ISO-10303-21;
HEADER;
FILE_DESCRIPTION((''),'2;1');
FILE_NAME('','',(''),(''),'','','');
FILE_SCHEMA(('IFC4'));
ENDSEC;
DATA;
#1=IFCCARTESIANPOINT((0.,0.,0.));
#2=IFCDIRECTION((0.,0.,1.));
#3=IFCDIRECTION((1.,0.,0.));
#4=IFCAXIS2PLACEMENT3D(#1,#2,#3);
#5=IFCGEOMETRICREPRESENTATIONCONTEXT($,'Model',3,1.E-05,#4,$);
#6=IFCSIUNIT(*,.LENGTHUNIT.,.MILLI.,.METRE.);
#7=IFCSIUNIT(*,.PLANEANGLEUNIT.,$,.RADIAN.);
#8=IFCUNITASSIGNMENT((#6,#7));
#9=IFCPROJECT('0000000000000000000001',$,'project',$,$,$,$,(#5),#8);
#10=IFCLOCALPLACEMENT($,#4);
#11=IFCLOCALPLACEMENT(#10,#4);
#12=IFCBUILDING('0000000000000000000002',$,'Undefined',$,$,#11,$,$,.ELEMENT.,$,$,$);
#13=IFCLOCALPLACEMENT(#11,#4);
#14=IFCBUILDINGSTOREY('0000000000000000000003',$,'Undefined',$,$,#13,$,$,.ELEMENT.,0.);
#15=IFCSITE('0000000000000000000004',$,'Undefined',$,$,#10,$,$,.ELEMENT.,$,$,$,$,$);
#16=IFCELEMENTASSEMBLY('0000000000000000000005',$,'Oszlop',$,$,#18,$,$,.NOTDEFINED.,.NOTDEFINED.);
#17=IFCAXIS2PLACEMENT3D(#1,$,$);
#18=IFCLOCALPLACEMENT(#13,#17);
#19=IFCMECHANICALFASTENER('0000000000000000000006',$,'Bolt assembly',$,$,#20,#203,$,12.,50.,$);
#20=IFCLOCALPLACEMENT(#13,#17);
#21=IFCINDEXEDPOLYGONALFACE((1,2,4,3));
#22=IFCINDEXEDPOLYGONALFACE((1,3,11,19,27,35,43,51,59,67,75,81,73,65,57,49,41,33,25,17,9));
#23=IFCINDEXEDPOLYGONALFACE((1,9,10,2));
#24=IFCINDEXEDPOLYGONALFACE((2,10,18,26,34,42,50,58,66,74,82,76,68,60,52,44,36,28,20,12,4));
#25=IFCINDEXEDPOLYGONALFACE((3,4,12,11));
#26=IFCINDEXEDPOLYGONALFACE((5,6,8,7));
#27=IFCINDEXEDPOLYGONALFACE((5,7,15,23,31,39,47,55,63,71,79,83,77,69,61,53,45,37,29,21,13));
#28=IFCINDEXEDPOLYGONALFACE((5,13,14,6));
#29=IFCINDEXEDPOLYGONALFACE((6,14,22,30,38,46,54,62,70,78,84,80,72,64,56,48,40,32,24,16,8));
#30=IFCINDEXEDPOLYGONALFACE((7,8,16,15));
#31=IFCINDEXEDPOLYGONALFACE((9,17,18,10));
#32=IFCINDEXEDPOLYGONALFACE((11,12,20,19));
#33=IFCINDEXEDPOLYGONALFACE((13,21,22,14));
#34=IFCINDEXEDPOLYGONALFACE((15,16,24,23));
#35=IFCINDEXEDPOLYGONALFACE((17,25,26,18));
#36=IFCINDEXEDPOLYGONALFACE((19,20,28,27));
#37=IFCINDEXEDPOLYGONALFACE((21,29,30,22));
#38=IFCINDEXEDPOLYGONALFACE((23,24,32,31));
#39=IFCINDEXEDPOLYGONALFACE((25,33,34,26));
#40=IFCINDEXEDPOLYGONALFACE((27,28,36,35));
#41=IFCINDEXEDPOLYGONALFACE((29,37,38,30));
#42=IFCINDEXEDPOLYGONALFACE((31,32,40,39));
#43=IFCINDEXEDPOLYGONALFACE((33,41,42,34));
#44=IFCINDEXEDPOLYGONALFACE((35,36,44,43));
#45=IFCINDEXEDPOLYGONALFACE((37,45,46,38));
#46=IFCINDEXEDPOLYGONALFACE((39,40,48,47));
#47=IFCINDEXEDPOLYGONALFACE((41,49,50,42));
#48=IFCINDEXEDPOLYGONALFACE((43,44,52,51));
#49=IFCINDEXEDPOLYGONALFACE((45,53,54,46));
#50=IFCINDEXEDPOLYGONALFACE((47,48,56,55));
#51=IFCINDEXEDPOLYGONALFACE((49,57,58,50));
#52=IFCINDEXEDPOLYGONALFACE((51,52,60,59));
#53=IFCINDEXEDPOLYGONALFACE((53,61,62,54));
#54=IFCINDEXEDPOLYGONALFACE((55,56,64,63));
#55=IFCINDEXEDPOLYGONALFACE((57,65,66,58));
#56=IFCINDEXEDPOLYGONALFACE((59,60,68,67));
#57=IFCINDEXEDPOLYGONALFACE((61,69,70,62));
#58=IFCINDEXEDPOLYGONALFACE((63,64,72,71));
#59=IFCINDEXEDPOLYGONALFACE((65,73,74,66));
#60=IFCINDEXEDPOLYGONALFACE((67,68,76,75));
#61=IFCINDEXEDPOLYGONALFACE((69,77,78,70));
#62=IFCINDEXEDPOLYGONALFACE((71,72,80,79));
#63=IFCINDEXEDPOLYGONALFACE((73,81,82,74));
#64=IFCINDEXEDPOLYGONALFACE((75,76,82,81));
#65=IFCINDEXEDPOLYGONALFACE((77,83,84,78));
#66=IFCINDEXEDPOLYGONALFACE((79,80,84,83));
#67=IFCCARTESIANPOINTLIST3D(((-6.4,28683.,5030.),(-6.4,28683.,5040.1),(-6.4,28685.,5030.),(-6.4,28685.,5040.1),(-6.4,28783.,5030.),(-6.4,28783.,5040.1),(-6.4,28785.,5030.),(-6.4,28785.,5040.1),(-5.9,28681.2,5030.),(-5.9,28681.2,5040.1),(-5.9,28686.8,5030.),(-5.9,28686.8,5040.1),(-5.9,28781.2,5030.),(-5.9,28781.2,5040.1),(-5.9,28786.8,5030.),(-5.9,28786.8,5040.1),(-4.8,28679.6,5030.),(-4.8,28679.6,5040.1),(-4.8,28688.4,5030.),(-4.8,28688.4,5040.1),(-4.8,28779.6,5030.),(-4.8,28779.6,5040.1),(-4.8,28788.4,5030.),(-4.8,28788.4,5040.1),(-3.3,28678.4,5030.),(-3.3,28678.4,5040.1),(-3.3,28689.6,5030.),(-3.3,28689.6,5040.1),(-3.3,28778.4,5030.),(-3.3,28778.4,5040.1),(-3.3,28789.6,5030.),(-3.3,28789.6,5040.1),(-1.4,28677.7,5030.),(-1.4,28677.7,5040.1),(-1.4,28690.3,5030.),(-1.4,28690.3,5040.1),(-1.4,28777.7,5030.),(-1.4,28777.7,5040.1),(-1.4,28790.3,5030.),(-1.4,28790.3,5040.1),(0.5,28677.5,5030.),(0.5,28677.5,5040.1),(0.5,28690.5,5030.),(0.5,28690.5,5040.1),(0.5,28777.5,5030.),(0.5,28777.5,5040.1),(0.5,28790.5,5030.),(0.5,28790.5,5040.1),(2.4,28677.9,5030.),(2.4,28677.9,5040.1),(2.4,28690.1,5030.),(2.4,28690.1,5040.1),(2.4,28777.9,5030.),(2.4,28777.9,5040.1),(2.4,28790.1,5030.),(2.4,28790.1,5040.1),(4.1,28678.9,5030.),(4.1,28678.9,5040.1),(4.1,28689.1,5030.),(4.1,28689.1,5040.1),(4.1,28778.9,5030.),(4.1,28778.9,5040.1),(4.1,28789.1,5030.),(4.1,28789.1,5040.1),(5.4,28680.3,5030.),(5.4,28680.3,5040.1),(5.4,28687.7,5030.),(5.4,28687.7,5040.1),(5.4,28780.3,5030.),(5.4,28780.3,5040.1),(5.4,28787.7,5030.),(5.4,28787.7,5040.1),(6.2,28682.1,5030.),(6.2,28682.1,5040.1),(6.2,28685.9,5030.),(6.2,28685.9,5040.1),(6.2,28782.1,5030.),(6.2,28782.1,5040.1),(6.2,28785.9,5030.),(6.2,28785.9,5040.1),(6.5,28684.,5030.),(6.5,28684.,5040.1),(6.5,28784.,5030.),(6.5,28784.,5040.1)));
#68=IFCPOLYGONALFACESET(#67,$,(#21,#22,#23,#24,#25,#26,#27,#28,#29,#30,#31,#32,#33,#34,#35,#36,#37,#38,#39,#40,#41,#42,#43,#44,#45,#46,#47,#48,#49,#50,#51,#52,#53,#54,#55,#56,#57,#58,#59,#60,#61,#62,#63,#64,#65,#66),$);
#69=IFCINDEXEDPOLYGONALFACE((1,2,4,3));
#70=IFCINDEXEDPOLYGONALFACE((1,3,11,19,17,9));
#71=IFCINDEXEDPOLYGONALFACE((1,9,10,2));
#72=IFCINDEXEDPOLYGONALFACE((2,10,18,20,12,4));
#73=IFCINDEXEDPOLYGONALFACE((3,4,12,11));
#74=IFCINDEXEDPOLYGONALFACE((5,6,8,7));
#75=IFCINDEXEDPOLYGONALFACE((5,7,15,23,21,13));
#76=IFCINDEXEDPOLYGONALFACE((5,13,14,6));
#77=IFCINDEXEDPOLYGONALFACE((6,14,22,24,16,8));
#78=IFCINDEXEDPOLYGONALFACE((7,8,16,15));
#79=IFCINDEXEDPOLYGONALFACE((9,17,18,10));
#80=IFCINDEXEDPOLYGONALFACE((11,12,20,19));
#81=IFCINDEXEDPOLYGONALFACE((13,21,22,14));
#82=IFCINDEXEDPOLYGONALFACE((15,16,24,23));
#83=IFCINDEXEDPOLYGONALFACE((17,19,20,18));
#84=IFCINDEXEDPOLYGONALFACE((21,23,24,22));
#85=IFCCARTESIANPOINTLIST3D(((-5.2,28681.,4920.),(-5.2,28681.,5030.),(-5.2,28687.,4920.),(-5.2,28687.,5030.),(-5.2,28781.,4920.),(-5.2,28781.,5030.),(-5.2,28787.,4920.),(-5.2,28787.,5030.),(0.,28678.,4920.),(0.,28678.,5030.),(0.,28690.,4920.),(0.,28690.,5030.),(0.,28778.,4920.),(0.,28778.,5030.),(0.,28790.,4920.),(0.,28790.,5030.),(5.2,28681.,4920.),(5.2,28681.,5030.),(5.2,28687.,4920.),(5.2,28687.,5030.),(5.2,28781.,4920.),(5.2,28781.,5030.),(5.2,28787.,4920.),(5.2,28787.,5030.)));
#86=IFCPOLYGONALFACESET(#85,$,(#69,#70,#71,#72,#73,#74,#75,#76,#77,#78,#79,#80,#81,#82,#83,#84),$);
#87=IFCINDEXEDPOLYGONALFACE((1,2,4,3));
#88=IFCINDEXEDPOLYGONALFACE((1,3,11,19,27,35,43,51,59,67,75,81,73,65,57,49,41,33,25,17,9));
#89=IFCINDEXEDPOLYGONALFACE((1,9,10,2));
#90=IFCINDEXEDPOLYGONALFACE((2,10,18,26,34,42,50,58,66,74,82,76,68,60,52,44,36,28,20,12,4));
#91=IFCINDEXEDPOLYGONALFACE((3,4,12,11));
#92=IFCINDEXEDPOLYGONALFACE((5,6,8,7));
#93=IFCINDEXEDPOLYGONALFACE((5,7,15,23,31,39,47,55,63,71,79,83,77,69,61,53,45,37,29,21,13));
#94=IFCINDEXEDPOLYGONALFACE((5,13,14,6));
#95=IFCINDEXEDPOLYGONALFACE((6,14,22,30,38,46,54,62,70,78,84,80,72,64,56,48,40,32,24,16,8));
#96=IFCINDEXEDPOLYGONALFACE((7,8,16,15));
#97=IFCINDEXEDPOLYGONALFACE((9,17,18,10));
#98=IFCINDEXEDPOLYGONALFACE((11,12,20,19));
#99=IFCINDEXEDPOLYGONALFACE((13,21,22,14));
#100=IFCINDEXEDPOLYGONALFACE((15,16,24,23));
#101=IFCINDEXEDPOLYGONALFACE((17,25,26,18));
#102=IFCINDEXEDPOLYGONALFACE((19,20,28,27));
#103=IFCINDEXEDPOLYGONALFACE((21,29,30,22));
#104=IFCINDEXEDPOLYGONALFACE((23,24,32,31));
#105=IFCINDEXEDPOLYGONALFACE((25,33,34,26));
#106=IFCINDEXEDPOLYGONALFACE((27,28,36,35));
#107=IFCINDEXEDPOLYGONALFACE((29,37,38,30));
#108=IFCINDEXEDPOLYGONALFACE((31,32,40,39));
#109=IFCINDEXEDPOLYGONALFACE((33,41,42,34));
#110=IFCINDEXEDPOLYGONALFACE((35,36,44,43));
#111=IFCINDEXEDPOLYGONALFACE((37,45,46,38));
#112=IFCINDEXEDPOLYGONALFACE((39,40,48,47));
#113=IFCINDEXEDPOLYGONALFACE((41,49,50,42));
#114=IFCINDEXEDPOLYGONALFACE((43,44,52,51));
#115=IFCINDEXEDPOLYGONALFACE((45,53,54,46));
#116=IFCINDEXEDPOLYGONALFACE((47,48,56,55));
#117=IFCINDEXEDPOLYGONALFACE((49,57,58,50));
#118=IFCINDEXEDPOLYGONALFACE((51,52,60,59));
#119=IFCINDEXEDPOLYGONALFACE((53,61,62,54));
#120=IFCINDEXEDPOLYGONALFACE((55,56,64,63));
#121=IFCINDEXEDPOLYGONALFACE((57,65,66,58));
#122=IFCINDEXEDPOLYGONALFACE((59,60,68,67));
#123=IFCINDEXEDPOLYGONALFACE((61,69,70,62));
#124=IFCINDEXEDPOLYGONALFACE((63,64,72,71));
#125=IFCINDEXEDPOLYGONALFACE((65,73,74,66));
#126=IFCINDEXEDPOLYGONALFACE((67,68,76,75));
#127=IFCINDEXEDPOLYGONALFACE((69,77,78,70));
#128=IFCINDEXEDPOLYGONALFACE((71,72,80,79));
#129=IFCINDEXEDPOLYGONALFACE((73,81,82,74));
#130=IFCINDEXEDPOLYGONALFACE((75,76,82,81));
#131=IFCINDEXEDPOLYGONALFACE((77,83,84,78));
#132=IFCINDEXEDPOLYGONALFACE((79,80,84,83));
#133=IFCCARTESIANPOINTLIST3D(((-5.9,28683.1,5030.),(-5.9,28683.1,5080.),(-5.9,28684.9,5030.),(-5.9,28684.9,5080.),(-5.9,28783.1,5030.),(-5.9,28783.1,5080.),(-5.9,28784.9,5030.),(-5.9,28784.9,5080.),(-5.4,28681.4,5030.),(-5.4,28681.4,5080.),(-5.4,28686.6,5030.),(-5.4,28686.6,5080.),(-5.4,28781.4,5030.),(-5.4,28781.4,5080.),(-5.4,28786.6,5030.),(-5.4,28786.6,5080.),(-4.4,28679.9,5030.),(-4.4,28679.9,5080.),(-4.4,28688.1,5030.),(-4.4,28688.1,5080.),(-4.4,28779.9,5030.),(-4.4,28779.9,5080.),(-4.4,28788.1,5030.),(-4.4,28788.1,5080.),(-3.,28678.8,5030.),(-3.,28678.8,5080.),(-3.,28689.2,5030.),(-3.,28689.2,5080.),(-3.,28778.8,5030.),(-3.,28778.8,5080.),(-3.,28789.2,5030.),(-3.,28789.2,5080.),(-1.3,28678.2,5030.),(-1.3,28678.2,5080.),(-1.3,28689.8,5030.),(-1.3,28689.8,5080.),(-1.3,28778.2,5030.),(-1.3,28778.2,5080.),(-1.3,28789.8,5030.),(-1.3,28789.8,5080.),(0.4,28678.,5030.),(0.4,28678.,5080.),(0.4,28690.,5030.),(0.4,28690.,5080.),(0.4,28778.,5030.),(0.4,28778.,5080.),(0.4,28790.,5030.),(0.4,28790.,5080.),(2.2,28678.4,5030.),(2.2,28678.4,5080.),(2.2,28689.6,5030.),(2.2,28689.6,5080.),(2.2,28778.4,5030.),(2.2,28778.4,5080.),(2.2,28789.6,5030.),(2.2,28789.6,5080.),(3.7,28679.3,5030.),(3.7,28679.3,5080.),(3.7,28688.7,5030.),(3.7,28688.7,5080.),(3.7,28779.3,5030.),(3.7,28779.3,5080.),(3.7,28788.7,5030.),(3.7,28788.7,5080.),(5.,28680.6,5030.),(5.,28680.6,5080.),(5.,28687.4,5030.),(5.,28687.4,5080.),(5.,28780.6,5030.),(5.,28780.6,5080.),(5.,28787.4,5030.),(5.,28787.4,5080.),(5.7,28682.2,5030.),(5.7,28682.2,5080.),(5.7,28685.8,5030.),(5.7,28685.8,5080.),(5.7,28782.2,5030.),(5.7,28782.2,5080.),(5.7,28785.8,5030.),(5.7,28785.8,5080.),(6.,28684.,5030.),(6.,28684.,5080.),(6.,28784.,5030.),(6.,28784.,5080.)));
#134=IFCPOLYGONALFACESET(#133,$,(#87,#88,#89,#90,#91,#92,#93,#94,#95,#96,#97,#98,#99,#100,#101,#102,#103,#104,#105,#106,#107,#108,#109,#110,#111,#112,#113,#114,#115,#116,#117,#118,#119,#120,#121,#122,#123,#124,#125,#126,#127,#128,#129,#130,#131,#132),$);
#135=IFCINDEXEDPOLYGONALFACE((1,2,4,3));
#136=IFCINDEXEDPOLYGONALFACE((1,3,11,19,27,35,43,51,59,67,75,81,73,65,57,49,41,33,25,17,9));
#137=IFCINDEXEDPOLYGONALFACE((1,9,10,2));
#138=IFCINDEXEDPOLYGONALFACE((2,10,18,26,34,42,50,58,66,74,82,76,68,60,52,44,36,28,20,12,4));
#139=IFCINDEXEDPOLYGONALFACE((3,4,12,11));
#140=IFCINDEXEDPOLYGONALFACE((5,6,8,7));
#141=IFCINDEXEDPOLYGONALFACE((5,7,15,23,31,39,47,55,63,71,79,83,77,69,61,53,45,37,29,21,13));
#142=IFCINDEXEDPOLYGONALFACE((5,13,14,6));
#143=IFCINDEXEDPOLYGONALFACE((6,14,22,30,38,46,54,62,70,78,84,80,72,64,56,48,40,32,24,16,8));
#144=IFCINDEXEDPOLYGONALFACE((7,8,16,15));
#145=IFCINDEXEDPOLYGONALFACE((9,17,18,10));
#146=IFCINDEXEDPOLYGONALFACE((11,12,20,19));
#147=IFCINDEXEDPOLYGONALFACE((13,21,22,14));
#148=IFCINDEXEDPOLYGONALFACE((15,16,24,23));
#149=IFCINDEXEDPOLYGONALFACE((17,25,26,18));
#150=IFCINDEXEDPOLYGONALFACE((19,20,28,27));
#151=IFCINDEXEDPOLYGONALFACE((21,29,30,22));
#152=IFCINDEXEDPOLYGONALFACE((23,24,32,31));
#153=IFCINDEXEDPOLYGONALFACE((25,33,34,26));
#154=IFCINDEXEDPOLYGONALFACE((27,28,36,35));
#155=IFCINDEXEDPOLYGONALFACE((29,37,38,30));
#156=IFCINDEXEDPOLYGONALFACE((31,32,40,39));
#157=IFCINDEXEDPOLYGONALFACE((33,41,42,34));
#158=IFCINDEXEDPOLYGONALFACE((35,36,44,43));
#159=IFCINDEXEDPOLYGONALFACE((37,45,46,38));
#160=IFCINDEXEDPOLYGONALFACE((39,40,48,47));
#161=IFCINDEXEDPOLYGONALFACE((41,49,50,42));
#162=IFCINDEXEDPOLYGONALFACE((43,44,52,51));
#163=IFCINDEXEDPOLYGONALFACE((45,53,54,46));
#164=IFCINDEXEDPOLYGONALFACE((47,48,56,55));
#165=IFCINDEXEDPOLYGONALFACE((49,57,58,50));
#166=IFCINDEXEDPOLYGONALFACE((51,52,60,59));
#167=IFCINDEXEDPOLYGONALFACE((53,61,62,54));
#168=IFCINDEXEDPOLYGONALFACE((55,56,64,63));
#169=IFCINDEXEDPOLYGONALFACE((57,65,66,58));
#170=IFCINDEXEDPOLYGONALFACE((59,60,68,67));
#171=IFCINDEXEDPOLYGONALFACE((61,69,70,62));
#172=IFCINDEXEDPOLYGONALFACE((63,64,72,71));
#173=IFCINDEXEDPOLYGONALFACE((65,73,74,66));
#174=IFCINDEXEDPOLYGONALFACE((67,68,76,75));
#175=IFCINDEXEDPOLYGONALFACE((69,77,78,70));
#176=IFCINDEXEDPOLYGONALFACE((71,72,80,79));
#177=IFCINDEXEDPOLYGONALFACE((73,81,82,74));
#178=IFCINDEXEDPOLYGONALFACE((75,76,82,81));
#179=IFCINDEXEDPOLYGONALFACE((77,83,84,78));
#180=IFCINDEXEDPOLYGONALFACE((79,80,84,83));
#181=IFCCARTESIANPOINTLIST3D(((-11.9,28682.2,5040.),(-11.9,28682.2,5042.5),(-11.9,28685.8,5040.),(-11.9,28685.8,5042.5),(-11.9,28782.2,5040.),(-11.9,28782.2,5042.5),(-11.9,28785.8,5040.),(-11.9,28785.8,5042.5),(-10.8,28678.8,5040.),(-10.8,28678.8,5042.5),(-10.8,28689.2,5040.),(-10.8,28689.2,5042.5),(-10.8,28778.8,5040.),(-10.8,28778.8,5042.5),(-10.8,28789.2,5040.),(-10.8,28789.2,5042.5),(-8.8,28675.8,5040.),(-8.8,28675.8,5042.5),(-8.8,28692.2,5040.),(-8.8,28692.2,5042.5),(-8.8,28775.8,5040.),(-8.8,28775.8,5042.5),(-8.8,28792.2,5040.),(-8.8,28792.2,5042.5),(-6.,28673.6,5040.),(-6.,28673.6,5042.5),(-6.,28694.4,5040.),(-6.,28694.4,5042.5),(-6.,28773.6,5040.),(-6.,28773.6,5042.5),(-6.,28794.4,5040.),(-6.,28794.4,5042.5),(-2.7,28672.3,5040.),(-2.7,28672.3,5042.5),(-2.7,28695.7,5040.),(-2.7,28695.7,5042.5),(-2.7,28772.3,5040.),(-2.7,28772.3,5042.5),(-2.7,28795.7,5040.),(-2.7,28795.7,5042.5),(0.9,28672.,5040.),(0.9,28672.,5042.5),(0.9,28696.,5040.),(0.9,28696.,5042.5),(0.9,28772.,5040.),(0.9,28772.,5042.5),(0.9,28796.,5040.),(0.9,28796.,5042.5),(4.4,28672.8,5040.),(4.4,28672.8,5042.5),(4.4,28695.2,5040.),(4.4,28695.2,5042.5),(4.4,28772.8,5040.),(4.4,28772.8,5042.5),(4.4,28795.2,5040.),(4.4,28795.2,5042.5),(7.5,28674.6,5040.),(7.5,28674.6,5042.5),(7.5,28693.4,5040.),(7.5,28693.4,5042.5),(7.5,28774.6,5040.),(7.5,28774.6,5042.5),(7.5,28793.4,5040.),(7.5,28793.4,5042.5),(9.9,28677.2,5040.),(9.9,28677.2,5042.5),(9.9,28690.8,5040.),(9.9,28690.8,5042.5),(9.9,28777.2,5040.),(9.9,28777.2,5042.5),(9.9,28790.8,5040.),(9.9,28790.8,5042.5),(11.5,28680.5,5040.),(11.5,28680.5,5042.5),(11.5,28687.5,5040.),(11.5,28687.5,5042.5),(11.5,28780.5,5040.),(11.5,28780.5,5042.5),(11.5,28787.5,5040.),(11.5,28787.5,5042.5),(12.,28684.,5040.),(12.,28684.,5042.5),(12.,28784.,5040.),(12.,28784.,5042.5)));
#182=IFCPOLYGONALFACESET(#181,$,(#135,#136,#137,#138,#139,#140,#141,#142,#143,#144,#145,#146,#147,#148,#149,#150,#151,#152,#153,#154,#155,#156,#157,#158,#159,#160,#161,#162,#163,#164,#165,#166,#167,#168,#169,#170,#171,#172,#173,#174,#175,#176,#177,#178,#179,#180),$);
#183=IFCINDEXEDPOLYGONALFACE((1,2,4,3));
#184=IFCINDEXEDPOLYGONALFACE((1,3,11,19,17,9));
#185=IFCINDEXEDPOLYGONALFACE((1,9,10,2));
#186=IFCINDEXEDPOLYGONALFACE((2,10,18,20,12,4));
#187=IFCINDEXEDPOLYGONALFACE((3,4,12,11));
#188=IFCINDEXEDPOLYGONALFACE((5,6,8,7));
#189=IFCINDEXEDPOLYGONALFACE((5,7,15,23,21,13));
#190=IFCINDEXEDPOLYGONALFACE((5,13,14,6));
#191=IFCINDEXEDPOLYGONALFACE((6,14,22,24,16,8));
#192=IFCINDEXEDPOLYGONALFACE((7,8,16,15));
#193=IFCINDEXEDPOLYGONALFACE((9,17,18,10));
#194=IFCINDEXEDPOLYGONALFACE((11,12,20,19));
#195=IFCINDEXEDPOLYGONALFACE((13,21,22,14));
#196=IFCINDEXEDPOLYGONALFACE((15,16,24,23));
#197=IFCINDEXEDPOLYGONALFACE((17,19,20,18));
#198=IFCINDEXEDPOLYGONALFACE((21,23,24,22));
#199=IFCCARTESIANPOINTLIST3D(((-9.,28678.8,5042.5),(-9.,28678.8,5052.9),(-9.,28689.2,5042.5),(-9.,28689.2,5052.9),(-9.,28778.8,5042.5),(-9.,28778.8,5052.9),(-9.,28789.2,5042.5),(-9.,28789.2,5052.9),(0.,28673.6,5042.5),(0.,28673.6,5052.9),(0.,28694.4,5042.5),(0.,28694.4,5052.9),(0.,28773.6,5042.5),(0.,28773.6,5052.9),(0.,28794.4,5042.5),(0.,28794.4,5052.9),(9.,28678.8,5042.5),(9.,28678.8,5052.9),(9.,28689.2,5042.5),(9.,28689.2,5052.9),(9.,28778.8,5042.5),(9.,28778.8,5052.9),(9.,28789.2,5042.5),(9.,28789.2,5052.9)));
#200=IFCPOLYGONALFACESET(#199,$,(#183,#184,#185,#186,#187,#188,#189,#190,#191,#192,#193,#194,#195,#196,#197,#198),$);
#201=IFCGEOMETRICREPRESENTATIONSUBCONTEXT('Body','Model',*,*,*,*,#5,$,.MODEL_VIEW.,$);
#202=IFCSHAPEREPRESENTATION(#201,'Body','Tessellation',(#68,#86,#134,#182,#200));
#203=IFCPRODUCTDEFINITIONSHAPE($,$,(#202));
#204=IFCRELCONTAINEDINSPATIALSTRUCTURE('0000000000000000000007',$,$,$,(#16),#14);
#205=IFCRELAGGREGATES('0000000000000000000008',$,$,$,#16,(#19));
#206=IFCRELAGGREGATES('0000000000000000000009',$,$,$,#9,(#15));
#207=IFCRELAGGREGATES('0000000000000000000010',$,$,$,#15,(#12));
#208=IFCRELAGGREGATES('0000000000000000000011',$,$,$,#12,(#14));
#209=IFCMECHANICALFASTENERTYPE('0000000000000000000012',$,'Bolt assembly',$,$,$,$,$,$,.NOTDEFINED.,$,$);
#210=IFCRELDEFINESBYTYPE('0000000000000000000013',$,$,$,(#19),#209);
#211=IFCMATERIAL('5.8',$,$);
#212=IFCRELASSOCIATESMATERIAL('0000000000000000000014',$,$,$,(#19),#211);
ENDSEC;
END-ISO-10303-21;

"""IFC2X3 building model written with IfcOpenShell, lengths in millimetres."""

from ifc_helpers import new_model, si_unit, frame, origin_with_axes, origin_2d_with_axis, place, context, subcontext, project, spatial, polyline, circle, outline, extrude, source, transform, mapped, material, type_object, element, aggregate, save


model = new_model("IFC2X3")

# Units and contexts
model_context = context("Model", 3, precision=1e-05, world=origin_with_axes())
body_context = subcontext(model_context, "Body", "Model", "MODEL_VIEW")
ifc_project = project(units=[si_unit("LENGTHUNIT", "METRE", prefix="MILLI"), si_unit("PLANEANGLEUNIT", "RADIAN")], contexts=[model_context])

# Site, building, storey
site_placement = place(None, origin_with_axes())
site = spatial("IfcSite", under=ifc_project, at=site_placement, Name="Undefined", CompositionType="ELEMENT")
building_placement = place(site_placement, origin_with_axes())
building = spatial("IfcBuilding", under=site, at=building_placement, Name="Undefined", CompositionType="ELEMENT")
storey_placement = place(building_placement, origin_with_axes())
storey = spatial("IfcBuildingStorey", under=building, at=storey_placement, Name="Undefined", CompositionType="ELEMENT", Elevation=0.0)

# Element assembly
assembly_1_placement = place(storey_placement, origin_with_axes())
assembly_1 = element("IfcElementAssembly", 1, at=assembly_1_placement, inside=storey, Name="Oszlop", AssemblyPlace="NOTDEFINED", PredefinedType="NOTDEFINED")

# Mechanical fastener
ifc_material_1 = material(Name="5.8")
mechanical_fastener_type = type_object("IfcMechanicalFastenerType", Name="Bolt assembly")
shared_shape_1 = source(origin_with_axes(), body_context, "Body", "SweptSolid", [
    extrude(circle(Radius=6.5, at=origin_2d_with_axis()), frame((0.0, -10.0, 0.0), z_axis=(0.0, 1.0, 0.0), x_axis=(1.0, 0.0, 0.0)), (0.0, 0.0, 1.0), 10.1),
    extrude(outline(polyline([(5.2, -3.0), (5.2, 3.0), (0.0, 6.0), (-5.2, 3.0), (-5.2, -3.0), (0.0, -6.0), (5.2, -3.0)])), frame((0.0, -120.0, 0.0), z_axis=(0.0, 1.0, 0.0), x_axis=(1.0, 0.0, 0.0)), (0.0, 0.0, 1.0), 110.0),
    extrude(circle(Radius=6.0, at=origin_2d_with_axis()), frame((0.0, -10.0, 0.0), z_axis=(0.0, 1.0, 0.0), x_axis=(1.0, 0.0, 0.0)), (0.0, 0.0, 1.0), 50.0),
    extrude(circle(Radius=12.0, at=origin_2d_with_axis()), frame((0.0, 0.0, 0.0), z_axis=(0.0, 1.0, 0.0), x_axis=(1.0, 0.0, 0.0)), (0.0, 0.0, 1.0), 2.5),
    extrude(outline(polyline([(9.0, -5.2), (9.0, 5.2), (0.0, 10.4), (-9.0, 5.2), (-9.0, -5.2), (0.0, -10.4), (9.0, -5.2)])), frame((0.0, 2.5, 0.0), z_axis=(0.0, 1.0, 0.0), x_axis=(1.0, 0.0, 0.0)), (0.0, 0.0, 1.0), 10.4),
])
mechanical_fastener_1_placement = place(assembly_1_placement, frame((-48.0, 28734.0, 5040.0), z_axis=(0.0, -1.0, 0.0), x_axis=(1.0, 0.0, 0.0)))
mechanical_fastener_1 = element("IfcMechanicalFastener", 2, at=mechanical_fastener_1_placement, type_object=mechanical_fastener_type, material=ifc_material_1, Name="Bolt assembly", NominalDiameter=12.0, NominalLength=50.0, context=body_context, shape_type="MappedRepresentation", body=[
    mapped(shared_shape_1, transform((48.0, 0.0, -50.0))),
    mapped(shared_shape_1, transform((48.0, 0.0, 50.0))),
])
aggregate(assembly_1, [mechanical_fastener_1])

save(model, "model.ifc")
